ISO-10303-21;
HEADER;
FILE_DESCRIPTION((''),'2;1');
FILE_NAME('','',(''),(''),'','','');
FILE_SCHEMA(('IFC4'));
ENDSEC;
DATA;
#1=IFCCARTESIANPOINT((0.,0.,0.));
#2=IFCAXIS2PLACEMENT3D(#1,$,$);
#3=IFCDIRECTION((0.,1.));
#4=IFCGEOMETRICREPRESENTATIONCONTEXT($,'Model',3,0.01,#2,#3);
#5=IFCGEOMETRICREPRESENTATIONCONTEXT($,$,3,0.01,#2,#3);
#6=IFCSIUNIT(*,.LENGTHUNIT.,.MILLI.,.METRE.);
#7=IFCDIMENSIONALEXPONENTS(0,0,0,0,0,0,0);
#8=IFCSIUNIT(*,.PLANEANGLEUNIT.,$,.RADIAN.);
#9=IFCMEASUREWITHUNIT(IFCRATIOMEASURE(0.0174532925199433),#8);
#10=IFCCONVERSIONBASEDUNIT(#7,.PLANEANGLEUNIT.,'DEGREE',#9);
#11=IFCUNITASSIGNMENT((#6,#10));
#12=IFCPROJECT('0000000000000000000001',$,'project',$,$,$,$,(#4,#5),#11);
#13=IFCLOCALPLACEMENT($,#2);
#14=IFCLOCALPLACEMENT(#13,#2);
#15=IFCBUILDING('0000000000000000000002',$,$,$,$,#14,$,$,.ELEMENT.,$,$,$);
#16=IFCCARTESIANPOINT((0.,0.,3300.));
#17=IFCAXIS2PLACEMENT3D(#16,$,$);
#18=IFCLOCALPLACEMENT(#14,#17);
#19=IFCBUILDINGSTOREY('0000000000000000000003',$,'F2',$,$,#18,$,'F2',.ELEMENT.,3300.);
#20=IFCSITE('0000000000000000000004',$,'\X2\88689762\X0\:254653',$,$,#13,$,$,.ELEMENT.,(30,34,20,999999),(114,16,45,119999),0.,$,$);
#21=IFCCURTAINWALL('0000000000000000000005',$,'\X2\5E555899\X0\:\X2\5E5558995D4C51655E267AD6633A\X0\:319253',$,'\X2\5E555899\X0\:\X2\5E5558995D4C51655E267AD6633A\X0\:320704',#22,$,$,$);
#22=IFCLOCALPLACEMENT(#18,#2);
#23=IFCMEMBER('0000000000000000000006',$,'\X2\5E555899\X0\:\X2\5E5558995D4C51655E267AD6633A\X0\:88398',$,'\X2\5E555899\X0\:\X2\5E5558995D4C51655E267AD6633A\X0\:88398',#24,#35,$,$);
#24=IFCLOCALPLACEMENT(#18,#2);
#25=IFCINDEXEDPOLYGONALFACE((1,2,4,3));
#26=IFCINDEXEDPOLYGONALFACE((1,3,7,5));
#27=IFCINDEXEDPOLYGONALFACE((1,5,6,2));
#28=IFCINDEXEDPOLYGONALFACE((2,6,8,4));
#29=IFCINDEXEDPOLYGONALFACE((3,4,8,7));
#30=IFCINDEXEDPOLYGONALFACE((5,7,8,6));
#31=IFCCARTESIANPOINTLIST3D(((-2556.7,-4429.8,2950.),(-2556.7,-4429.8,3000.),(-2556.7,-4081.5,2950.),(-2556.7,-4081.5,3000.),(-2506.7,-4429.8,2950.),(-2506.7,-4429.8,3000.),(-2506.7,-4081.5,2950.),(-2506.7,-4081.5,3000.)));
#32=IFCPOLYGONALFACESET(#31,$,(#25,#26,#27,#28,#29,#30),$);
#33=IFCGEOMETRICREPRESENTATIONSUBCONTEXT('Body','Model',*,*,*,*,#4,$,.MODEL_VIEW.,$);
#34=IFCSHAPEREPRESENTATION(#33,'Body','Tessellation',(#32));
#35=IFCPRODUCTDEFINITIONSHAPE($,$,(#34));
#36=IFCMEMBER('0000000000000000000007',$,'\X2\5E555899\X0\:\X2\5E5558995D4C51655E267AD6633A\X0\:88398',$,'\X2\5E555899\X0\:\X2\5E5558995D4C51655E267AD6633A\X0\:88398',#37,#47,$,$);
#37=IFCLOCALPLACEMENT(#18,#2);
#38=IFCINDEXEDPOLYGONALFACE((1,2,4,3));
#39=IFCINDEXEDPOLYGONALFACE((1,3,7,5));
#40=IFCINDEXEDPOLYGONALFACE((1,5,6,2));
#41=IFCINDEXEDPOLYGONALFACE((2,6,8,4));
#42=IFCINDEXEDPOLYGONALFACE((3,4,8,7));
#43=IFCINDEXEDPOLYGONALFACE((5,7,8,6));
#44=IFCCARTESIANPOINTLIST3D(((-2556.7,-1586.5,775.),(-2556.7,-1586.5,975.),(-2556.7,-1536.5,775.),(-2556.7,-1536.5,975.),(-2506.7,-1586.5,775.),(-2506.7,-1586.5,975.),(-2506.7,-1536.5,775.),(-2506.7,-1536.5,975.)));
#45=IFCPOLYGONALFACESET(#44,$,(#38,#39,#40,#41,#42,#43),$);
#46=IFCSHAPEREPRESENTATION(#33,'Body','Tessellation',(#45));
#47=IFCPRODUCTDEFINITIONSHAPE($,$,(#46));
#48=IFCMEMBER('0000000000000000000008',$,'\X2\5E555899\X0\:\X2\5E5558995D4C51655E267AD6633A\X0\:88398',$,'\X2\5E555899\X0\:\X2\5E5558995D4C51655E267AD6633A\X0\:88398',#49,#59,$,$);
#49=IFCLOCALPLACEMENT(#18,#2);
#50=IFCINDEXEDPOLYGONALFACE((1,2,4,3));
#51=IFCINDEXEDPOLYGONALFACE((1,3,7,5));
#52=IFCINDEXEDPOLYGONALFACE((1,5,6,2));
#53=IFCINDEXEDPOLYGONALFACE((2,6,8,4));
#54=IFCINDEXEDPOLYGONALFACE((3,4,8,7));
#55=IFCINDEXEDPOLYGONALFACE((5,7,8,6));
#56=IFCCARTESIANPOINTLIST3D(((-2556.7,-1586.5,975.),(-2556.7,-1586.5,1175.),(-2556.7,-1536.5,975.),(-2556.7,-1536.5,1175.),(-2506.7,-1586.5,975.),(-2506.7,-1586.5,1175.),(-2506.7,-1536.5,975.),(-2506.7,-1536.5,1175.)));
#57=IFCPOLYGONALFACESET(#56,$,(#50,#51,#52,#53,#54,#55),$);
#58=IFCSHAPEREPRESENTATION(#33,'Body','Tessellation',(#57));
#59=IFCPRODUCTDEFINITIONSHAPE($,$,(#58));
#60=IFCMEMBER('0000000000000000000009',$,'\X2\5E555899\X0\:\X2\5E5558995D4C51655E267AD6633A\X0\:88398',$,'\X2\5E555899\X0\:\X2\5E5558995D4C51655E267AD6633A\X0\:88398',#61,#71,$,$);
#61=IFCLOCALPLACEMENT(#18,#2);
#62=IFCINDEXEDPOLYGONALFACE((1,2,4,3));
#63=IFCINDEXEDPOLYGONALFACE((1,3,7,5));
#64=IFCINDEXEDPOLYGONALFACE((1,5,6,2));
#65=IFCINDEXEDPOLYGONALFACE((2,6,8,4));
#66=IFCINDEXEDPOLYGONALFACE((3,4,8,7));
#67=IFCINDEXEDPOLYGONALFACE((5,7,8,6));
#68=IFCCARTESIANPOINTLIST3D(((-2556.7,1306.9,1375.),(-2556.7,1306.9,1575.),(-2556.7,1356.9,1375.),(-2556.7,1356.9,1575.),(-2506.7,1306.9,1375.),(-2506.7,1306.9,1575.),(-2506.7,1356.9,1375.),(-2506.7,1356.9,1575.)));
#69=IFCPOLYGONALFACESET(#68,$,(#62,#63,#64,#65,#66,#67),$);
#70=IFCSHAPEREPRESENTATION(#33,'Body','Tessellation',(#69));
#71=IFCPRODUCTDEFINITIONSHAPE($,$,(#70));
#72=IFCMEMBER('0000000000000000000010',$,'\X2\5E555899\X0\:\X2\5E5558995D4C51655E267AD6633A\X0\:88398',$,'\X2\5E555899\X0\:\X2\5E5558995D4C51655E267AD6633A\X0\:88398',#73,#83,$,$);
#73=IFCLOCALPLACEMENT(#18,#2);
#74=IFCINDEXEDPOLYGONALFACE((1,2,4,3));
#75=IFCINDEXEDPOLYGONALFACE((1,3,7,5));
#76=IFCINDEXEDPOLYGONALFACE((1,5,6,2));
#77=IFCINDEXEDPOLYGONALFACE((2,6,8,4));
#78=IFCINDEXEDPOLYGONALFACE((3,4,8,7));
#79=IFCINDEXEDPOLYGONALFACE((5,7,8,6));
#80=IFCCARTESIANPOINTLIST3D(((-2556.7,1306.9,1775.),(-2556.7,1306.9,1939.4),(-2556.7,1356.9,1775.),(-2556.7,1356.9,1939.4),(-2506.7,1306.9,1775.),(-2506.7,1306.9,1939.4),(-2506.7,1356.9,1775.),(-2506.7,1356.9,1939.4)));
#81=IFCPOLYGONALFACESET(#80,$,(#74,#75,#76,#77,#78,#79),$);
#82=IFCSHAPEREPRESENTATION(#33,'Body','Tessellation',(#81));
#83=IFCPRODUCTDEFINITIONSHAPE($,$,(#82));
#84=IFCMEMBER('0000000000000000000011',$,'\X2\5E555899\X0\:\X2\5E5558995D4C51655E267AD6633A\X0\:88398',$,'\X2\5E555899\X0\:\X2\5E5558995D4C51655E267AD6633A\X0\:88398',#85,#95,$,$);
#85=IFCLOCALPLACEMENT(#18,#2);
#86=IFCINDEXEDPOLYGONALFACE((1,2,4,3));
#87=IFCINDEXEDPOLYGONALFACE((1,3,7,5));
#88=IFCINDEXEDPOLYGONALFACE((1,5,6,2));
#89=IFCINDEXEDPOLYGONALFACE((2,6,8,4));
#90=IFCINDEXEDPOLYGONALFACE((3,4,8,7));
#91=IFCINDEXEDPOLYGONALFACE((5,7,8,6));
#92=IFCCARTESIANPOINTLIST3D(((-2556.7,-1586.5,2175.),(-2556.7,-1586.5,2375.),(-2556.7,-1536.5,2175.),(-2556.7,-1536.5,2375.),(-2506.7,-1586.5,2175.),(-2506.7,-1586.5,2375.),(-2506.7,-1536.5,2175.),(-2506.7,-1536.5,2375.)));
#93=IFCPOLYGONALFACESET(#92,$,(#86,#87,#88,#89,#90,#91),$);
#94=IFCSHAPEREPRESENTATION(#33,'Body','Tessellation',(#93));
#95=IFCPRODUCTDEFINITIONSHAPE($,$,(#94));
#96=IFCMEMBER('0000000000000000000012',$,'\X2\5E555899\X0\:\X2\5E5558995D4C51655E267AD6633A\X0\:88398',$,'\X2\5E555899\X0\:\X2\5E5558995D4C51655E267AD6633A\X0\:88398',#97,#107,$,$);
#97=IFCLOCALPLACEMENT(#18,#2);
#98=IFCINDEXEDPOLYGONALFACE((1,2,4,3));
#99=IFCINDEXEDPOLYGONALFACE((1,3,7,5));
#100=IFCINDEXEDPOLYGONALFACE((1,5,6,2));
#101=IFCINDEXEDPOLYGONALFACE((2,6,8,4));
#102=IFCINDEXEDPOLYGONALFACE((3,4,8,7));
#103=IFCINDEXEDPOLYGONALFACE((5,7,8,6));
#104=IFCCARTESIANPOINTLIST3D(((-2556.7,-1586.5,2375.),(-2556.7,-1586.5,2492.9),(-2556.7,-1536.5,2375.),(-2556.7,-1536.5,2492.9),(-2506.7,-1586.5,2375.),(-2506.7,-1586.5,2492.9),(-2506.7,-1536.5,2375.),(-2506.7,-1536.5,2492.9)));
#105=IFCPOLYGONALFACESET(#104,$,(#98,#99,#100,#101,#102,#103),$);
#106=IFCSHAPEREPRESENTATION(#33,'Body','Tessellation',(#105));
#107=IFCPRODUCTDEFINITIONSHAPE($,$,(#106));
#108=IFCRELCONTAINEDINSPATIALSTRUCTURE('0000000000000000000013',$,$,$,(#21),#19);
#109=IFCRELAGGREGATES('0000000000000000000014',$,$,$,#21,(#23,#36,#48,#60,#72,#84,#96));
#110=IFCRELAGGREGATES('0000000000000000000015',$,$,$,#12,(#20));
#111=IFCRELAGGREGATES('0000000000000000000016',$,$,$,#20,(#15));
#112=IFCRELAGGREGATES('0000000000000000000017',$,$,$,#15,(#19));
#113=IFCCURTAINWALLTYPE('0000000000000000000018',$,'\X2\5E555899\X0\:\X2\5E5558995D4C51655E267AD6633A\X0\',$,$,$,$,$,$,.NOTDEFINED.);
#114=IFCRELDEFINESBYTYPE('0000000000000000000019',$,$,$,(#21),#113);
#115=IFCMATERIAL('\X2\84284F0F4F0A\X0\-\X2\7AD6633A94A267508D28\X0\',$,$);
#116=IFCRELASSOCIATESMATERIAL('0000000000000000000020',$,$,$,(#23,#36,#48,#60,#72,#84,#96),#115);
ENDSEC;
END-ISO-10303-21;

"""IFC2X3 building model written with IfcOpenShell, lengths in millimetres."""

from ifc_helpers import new_model, entity, si_unit, converted_unit, direction, frame, origin, origin_2d_with_axis, place, context, subcontext, project, spatial, rectangle, extrude, material, type_object, element, aggregate, save


model = new_model("IFC2X3")

# Units and contexts
model_context = context("Model", 3, precision=0.01, world=origin(), true_north=direction((0.0, 1.0)))
context_of_model = context(None, 3, precision=0.01, world=origin(), true_north=direction((0.0, 1.0)))
body_context = subcontext(model_context, "Body", "Model", "MODEL_VIEW")
ifc_project = project(units=[si_unit("LENGTHUNIT", "METRE", prefix="MILLI"), converted_unit("PLANEANGLEUNIT", "DEGREE", entity("IfcRatioMeasure", 0.0174532925199433), si_unit("PLANEANGLEUNIT", "RADIAN"), dimensions=[0, 0, 0, 0, 0, 0, 0])], contexts=[model_context, context_of_model])

# Site, building, storey
site_placement = place(None, origin())
site = spatial("IfcSite", under=ifc_project, at=site_placement, Name="表面:254653", CompositionType="ELEMENT", RefLatitude=(30, 34, 20, 999999), RefLongitude=(114, 16, 45, 119999), RefElevation=0.0)
building_placement = place(site_placement, origin())
building = spatial("IfcBuilding", under=site, at=building_placement, CompositionType="ELEMENT")
storey_placement = place(building_placement, frame((0.0, 0.0, 3300.0)))
storey = spatial("IfcBuildingStorey", under=building, at=storey_placement, Name="F2", LongName="F2", CompositionType="ELEMENT", Elevation=3300.0)

# Curtain wall, members
curtain_wall_type = type_object("IfcCurtainWallType", Name="幕墙:幕墙嵌入带竖挺", PredefinedType="NOTDEFINED")
curtain_wall_placement = place(storey_placement, frame((0.0, 0.0, -3300.0)))
curtain_wall = element("IfcCurtainWall", 1, at=curtain_wall_placement, inside=storey, type_object=curtain_wall_type, Name="幕墙:幕墙嵌入带竖挺:319253", ObjectType="幕墙:幕墙嵌入带竖挺:320704")
ifc_material = material(Name="萨伏伊-竖挺钢材质")
member_1_placement = place(curtain_wall_placement, frame((0.0, 0.0, 3300.0)))
member_1 = element("IfcMember", 2, at=member_1_placement, material=ifc_material, Name="幕墙:幕墙嵌入带竖挺:88398", ObjectType="幕墙:幕墙嵌入带竖挺:88398", context=body_context, shape_type="SweptSolid", body=[
    extrude(rectangle(XDim=50.0, YDim=50.0, at=origin_2d_with_axis()), frame((-2531.7, -4429.8, 2975.0), z_axis=(0.0, 1.0, 0.0), x_axis=(0.0, 0.0, -1.0)), (0.0, 0.0, 1.0), 348.3),
])
member_2_placement = place(curtain_wall_placement, frame((0.0, 0.0, 3300.0)))
member_2 = element("IfcMember", 3, at=member_2_placement, material=ifc_material, Name="幕墙:幕墙嵌入带竖挺:88398", ObjectType="幕墙:幕墙嵌入带竖挺:88398", context=body_context, shape_type="SweptSolid", body=[
    extrude(rectangle(XDim=50.0, YDim=50.0, at=origin_2d_with_axis()), frame((-2531.7, -1561.5, 775.0), z_axis=(0.0, 0.0, 1.0), x_axis=(-1.0, 0.0, 0.0)), (0.0, 0.0, 1.0), 200.0),
])
member_3_placement = place(curtain_wall_placement, frame((0.0, 0.0, 3300.0)))
member_3 = element("IfcMember", 4, at=member_3_placement, material=ifc_material, Name="幕墙:幕墙嵌入带竖挺:88398", ObjectType="幕墙:幕墙嵌入带竖挺:88398", context=body_context, shape_type="SweptSolid", body=[
    extrude(rectangle(XDim=50.0, YDim=50.0, at=origin_2d_with_axis()), frame((-2531.7, -1561.5, 975.0), z_axis=(0.0, 0.0, 1.0), x_axis=(-1.0, 0.0, 0.0)), (0.0, 0.0, 1.0), 200.0),
])
member_4_placement = place(curtain_wall_placement, frame((0.0, 0.0, 3300.0)))
member_4 = element("IfcMember", 5, at=member_4_placement, material=ifc_material, Name="幕墙:幕墙嵌入带竖挺:88398", ObjectType="幕墙:幕墙嵌入带竖挺:88398", context=body_context, shape_type="SweptSolid", body=[
    extrude(rectangle(XDim=50.0, YDim=50.0, at=origin_2d_with_axis()), frame((-2531.7, 1331.9, 1375.0), z_axis=(0.0, 0.0, 1.0), x_axis=(-1.0, 0.0, 0.0)), (0.0, 0.0, 1.0), 200.0),
])
member_5_placement = place(curtain_wall_placement, frame((0.0, 0.0, 3300.0)))
member_5 = element("IfcMember", 6, at=member_5_placement, material=ifc_material, Name="幕墙:幕墙嵌入带竖挺:88398", ObjectType="幕墙:幕墙嵌入带竖挺:88398", context=body_context, shape_type="SweptSolid", body=[
    extrude(rectangle(XDim=50.0, YDim=50.0, at=origin_2d_with_axis()), frame((-2531.7, 1331.9, 1775.0), z_axis=(0.0, 0.0, 1.0), x_axis=(-1.0, 0.0, 0.0)), (0.0, 0.0, 1.0), 164.4),
])
member_6_placement = place(curtain_wall_placement, frame((0.0, 0.0, 3300.0)))
member_6 = element("IfcMember", 7, at=member_6_placement, material=ifc_material, Name="幕墙:幕墙嵌入带竖挺:88398", ObjectType="幕墙:幕墙嵌入带竖挺:88398", context=body_context, shape_type="SweptSolid", body=[
    extrude(rectangle(XDim=50.0, YDim=50.0, at=origin_2d_with_axis()), frame((-2531.7, -1561.5, 2175.0), z_axis=(0.0, 0.0, 1.0), x_axis=(-1.0, 0.0, 0.0)), (0.0, 0.0, 1.0), 200.0),
])
member_7_placement = place(curtain_wall_placement, frame((0.0, 0.0, 3300.0)))
member_7 = element("IfcMember", 8, at=member_7_placement, material=ifc_material, Name="幕墙:幕墙嵌入带竖挺:88398", ObjectType="幕墙:幕墙嵌入带竖挺:88398", context=body_context, shape_type="SweptSolid", body=[
    extrude(rectangle(XDim=50.0, YDim=50.0, at=origin_2d_with_axis()), frame((-2531.7, -1561.5, 2375.0), z_axis=(0.0, 0.0, 1.0), x_axis=(-1.0, 0.0, 0.0)), (0.0, 0.0, 1.0), 117.9),
])
aggregate(curtain_wall, [member_1, member_2, member_3, member_4, member_5, member_6, member_7])

save(model, "model.ifc")
